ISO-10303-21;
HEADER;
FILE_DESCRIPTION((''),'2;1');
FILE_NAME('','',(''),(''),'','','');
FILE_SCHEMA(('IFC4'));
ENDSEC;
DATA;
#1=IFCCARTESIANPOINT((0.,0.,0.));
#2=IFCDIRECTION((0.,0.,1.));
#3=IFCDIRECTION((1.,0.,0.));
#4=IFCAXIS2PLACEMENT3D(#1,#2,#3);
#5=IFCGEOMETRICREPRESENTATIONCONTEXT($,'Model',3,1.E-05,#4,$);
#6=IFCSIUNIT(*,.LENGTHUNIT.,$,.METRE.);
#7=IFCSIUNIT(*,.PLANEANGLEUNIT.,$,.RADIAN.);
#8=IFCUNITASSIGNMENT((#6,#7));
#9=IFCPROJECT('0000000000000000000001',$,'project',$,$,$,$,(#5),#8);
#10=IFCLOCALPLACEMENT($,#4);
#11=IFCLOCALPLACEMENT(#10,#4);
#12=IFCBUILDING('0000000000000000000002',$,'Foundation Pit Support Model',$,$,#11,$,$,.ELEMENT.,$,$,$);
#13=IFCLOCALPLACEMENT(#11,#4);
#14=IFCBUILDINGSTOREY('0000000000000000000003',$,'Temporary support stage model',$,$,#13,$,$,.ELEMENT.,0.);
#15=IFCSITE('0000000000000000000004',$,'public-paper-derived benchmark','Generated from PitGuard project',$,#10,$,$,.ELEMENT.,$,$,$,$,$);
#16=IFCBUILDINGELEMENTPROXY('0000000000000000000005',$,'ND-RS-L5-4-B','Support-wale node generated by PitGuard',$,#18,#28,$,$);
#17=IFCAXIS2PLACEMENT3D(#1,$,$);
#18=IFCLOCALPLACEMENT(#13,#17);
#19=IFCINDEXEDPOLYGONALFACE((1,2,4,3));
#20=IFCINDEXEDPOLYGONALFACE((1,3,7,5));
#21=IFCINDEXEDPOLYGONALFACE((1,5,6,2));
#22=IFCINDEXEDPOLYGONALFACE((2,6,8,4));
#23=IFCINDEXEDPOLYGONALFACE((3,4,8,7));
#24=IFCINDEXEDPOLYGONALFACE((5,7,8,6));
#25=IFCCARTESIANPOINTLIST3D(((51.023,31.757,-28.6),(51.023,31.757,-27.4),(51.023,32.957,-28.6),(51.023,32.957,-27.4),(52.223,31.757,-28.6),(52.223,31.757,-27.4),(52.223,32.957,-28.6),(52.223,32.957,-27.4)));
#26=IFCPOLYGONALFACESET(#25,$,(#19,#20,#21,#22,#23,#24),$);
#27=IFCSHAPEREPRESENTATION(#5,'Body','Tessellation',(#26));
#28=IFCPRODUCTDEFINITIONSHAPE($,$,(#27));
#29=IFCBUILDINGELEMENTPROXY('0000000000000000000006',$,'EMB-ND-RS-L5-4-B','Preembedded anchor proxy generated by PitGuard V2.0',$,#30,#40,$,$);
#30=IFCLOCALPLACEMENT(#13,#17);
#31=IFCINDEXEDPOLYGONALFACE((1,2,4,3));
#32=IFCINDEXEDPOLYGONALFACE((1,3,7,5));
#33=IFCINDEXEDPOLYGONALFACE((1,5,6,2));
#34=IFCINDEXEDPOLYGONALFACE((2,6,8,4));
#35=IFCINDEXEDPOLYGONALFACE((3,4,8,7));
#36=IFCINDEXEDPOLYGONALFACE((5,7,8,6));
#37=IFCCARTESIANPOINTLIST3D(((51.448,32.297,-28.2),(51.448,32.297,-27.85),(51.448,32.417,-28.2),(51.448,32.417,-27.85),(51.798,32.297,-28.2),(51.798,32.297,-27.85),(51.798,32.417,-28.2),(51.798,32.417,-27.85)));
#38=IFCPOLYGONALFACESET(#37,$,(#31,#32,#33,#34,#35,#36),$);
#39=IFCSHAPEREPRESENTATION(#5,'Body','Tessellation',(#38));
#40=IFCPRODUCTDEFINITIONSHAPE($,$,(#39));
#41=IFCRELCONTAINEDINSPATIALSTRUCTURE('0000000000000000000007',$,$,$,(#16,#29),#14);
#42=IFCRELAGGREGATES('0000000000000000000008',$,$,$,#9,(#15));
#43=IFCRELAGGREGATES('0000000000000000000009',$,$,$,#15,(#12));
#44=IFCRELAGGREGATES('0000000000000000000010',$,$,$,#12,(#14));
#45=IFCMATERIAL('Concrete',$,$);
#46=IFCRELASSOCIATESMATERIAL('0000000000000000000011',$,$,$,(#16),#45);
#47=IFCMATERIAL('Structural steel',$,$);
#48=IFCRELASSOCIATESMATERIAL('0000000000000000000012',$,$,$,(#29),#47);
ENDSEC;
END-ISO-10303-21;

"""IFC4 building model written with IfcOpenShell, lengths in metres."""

from ifc_helpers import new_model, si_unit, frame, origin_with_axes, origin_2d, place, context, project, spatial, rectangle, extrude, material, element, save


model = new_model("IFC4")

# Units and contexts
model_context = context("Model", 3, precision=1e-05, world=origin_with_axes())
ifc_project = project(units=[si_unit("LENGTHUNIT", "METRE"), si_unit("PLANEANGLEUNIT", "RADIAN")], contexts=[model_context])

# Site, building, storey
site_placement = place(None, origin_with_axes())
site = spatial("IfcSite", under=ifc_project, at=site_placement, Name="public-paper-derived benchmark", Description="Generated from PitGuard project", CompositionType="ELEMENT")
building_placement = place(site_placement, origin_with_axes())
building = spatial("IfcBuilding", under=site, at=building_placement, Name="Foundation Pit Support Model", CompositionType="ELEMENT")
storey_placement = place(building_placement, origin_with_axes())
storey = spatial("IfcBuildingStorey", under=building, at=storey_placement, Name="Temporary support stage model", CompositionType="ELEMENT", Elevation=0.0)

# Shared definitions
ifc_material_1 = material(Name="Structural steel")

# Shared definitions
ifc_material_2 = material(Name="Concrete")

# Building element proxies
proxy_1_placement = place(storey_placement, frame((51.623, 32.357, -28.6), z_axis=(0.0, 0.0, 1.0), x_axis=(1.0, 0.0, 0.0)))
element("IfcBuildingElementProxy", 1, at=proxy_1_placement, inside=storey, material=ifc_material_2, Name="ND-RS-L5-4-B", Description="Support-wale node generated by PitGuard", context=model_context, shape_type="SweptSolid", body=[
    extrude(rectangle(XDim=1.2, YDim=1.2, at=origin_2d()), origin_with_axes(), (0.0, 0.0, 1.0), 1.2),
])
proxy_2_placement = place(storey_placement, frame((51.623, 32.357, -28.2), z_axis=(0.0, 0.0, 1.0), x_axis=(1.0, 0.0, 0.0)))
element("IfcBuildingElementProxy", 2, at=proxy_2_placement, inside=storey, material=ifc_material_1, Name="EMB-ND-RS-L5-4-B", Description="Preembedded anchor proxy generated by PitGuard V2.0", context=model_context, shape_type="SweptSolid", body=[
    extrude(rectangle(XDim=0.35, YDim=0.12, at=origin_2d()), origin_with_axes(), (0.0, 0.0, 1.0), 0.35),
])

save(model, "model.ifc")
